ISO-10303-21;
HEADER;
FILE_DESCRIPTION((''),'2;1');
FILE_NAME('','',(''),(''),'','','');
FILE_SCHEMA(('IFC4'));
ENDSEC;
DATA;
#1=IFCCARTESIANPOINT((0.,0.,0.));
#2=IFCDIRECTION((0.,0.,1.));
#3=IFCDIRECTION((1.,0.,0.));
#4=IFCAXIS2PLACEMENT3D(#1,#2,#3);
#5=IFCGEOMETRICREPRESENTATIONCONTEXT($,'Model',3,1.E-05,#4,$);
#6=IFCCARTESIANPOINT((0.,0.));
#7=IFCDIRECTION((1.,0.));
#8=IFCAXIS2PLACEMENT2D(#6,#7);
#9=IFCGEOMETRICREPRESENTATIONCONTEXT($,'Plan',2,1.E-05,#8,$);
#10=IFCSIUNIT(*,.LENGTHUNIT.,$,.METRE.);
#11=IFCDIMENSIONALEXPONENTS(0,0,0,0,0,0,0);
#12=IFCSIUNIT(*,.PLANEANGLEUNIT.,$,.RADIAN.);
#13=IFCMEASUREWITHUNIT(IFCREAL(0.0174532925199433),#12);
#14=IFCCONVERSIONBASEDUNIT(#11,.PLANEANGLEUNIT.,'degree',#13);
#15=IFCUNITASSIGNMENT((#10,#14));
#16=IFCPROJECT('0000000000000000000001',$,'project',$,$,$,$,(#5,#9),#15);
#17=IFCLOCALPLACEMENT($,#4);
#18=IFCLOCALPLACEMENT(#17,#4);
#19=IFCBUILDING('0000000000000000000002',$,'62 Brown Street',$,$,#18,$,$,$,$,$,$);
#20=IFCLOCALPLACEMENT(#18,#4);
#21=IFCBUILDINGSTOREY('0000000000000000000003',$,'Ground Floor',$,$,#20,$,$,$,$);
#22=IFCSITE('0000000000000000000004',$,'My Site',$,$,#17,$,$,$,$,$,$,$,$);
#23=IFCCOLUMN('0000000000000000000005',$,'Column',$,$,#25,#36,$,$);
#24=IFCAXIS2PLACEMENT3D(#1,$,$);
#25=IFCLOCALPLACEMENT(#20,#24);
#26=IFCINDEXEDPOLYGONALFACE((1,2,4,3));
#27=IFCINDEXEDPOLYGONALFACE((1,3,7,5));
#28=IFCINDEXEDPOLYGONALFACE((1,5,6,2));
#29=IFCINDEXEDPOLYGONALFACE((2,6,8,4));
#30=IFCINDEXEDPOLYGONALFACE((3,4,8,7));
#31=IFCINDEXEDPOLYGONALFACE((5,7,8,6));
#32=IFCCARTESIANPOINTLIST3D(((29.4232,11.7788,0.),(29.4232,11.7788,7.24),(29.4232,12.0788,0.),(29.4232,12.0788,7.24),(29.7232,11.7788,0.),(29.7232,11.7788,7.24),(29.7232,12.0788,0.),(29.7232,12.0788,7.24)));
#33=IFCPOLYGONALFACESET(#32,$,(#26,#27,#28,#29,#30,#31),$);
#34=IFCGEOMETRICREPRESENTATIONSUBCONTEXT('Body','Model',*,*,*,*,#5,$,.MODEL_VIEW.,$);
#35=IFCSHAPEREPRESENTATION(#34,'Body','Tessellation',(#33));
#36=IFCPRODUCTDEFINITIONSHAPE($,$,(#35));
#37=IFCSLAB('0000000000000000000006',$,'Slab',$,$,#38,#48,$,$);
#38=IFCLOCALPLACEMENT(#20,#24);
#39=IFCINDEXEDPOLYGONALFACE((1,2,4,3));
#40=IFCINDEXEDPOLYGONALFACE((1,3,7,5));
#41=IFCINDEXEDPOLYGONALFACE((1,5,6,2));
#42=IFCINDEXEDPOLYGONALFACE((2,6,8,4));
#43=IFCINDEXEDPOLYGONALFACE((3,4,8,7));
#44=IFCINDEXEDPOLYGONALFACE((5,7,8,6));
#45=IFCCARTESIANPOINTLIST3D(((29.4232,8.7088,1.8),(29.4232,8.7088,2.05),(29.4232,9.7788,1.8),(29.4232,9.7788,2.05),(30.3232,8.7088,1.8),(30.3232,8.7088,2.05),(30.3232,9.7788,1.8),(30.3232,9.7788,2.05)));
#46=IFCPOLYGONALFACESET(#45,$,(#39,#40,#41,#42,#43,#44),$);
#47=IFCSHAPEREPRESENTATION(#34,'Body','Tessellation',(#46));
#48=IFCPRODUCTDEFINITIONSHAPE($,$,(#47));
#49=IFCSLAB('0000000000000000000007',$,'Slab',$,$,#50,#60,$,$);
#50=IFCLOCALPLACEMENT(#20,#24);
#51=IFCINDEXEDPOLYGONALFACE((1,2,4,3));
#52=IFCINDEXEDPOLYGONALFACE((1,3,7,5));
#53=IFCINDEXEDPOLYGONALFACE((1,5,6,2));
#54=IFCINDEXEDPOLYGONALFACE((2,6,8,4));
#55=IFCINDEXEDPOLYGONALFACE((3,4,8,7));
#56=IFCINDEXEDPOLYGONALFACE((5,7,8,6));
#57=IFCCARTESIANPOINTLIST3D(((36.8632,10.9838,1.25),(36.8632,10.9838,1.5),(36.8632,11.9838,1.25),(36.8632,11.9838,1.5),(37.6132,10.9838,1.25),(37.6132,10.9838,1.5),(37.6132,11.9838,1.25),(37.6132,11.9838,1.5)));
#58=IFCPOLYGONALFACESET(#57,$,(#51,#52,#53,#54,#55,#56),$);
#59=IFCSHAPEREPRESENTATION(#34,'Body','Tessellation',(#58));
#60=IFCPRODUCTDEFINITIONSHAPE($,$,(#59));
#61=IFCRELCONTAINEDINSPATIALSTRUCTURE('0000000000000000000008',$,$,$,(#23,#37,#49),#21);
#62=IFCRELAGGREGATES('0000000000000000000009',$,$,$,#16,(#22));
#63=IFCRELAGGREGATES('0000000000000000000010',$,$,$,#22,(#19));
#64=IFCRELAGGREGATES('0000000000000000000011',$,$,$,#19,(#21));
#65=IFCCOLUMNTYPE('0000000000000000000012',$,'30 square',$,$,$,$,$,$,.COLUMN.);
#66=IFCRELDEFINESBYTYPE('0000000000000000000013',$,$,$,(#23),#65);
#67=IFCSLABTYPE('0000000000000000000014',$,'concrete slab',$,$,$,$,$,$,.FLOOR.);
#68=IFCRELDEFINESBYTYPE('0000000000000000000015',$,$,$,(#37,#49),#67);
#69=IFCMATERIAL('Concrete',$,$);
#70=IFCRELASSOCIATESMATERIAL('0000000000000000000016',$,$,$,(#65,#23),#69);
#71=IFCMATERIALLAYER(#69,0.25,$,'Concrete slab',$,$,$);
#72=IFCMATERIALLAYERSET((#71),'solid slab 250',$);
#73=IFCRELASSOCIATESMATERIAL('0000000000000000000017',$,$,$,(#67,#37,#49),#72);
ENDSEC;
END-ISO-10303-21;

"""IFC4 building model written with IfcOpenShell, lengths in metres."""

from ifc_helpers import new_model, entity, si_unit, converted_unit, frame, origin_with_axes, origin_2d_with_axis, place, context, subcontext, project, spatial, line, indexed_curve, rectangle, outline, extrude, material, layer, layer_set, layer_usage, material_profile, profile_set, profile_usage, type_object, element, save


model = new_model("IFC4")

# Units and contexts
model_context = context("Model", 3, precision=1e-05, world=origin_with_axes())
plan_context = context("Plan", 2, precision=1e-05, world=origin_2d_with_axis())
body_context_1 = subcontext(model_context, "Body", "Model", "MODEL_VIEW")
ifc_project = project(units=[si_unit("LENGTHUNIT", "METRE"), converted_unit("PLANEANGLEUNIT", "degree", entity("IfcReal", 0.0174532925199433), si_unit("PLANEANGLEUNIT", "RADIAN"), dimensions=[0, 0, 0, 0, 0, 0, 0])], contexts=[model_context, plan_context])

# Site, building, storey
site_placement = place(None, origin_with_axes())
site = spatial("IfcSite", under=ifc_project, at=site_placement, Name="My Site")
building_placement = place(site_placement, origin_with_axes())
building = spatial("IfcBuilding", under=site, at=building_placement, Name="62 Brown Street")
storey_placement = place(building_placement, origin_with_axes())
storey = spatial("IfcBuildingStorey", under=building, at=storey_placement, Name="Ground Floor")

# Column
ifc_material_1 = material(Name="Concrete")
ifc_material_profile_1 = material_profile(ifc_material_1, rectangle(XDim=0.3, YDim=0.3))
ifc_profile_set_1 = profile_set([ifc_material_profile_1])
ifc_profile_usage_1 = profile_usage(ifc_profile_set_1, cardinal=5)
column_type = type_object("IfcColumnType", Name="30 square", PredefinedType="COLUMN", material=ifc_profile_set_1)
column_placement = place(storey_placement, frame((29.5732, 11.9288, 0.0), z_axis=(0.0, 0.0, 1.0), x_axis=(1.0, 0.0, 0.0)))
element("IfcColumn", 1, at=column_placement, inside=storey, type_object=column_type, material=ifc_profile_usage_1, Name="Column", context=body_context_1, shape_type="SweptSolid", body=[
    extrude(rectangle(XDim=0.3, YDim=0.3), origin_with_axes(), (0.0, 0.0, 1.0), 7.24),
])

# Slabs
ifc_layer_1 = layer(ifc_material_1, 0.25, Name="Concrete slab")
ifc_layer_set_1 = layer_set([ifc_layer_1], Name="solid slab 250")
slab_type = type_object("IfcSlabType", Name="concrete slab", PredefinedType="FLOOR", material=ifc_layer_set_1)
ifc_layer_usage_1 = layer_usage(ifc_layer_set_1, "AXIS3", "POSITIVE", 0.0)
slab_1_placement = place(storey_placement, frame((29.4232, 8.7088, 1.8), z_axis=(0.0, 0.0, 1.0), x_axis=(1.0, 0.0, 0.0)))
element("IfcSlab", 2, at=slab_1_placement, inside=storey, type_object=slab_type, material=ifc_layer_usage_1, Name="Slab", context=body_context_1, shape_type="SweptSolid", body=[
    extrude(outline(indexed_curve([(0.9, 1.07), (0.9, 0.0), (0.0, 0.0), (0.0, 1.07)], segments=[line(3, 2), line(2, 1), line(1, 4), line(4, 3)], self_intersect=False)), None, (0.0, 0.0, 1.0), 0.25),
])
ifc_layer_usage_2 = layer_usage(ifc_layer_set_1, "AXIS3", "POSITIVE", 0.0)
slab_2_placement = place(storey_placement, frame((36.8632, 10.9838, 1.25), z_axis=(0.0, 0.0, 1.0), x_axis=(1.0, 0.0, 0.0)))
element("IfcSlab", 3, at=slab_2_placement, inside=storey, type_object=slab_type, material=ifc_layer_usage_2, Name="Slab", context=body_context_1, shape_type="SweptSolid", body=[
    extrude(outline(indexed_curve([(0.0, 0.0), (0.75, 0.0), (0.75, 1.0), (0.0, 1.0)], segments=[line(4, 1), line(1, 2), line(2, 3), line(3, 4)], self_intersect=False)), None, (0.0, 0.0, 1.0), 0.25),
])

save(model, "model.ifc")
